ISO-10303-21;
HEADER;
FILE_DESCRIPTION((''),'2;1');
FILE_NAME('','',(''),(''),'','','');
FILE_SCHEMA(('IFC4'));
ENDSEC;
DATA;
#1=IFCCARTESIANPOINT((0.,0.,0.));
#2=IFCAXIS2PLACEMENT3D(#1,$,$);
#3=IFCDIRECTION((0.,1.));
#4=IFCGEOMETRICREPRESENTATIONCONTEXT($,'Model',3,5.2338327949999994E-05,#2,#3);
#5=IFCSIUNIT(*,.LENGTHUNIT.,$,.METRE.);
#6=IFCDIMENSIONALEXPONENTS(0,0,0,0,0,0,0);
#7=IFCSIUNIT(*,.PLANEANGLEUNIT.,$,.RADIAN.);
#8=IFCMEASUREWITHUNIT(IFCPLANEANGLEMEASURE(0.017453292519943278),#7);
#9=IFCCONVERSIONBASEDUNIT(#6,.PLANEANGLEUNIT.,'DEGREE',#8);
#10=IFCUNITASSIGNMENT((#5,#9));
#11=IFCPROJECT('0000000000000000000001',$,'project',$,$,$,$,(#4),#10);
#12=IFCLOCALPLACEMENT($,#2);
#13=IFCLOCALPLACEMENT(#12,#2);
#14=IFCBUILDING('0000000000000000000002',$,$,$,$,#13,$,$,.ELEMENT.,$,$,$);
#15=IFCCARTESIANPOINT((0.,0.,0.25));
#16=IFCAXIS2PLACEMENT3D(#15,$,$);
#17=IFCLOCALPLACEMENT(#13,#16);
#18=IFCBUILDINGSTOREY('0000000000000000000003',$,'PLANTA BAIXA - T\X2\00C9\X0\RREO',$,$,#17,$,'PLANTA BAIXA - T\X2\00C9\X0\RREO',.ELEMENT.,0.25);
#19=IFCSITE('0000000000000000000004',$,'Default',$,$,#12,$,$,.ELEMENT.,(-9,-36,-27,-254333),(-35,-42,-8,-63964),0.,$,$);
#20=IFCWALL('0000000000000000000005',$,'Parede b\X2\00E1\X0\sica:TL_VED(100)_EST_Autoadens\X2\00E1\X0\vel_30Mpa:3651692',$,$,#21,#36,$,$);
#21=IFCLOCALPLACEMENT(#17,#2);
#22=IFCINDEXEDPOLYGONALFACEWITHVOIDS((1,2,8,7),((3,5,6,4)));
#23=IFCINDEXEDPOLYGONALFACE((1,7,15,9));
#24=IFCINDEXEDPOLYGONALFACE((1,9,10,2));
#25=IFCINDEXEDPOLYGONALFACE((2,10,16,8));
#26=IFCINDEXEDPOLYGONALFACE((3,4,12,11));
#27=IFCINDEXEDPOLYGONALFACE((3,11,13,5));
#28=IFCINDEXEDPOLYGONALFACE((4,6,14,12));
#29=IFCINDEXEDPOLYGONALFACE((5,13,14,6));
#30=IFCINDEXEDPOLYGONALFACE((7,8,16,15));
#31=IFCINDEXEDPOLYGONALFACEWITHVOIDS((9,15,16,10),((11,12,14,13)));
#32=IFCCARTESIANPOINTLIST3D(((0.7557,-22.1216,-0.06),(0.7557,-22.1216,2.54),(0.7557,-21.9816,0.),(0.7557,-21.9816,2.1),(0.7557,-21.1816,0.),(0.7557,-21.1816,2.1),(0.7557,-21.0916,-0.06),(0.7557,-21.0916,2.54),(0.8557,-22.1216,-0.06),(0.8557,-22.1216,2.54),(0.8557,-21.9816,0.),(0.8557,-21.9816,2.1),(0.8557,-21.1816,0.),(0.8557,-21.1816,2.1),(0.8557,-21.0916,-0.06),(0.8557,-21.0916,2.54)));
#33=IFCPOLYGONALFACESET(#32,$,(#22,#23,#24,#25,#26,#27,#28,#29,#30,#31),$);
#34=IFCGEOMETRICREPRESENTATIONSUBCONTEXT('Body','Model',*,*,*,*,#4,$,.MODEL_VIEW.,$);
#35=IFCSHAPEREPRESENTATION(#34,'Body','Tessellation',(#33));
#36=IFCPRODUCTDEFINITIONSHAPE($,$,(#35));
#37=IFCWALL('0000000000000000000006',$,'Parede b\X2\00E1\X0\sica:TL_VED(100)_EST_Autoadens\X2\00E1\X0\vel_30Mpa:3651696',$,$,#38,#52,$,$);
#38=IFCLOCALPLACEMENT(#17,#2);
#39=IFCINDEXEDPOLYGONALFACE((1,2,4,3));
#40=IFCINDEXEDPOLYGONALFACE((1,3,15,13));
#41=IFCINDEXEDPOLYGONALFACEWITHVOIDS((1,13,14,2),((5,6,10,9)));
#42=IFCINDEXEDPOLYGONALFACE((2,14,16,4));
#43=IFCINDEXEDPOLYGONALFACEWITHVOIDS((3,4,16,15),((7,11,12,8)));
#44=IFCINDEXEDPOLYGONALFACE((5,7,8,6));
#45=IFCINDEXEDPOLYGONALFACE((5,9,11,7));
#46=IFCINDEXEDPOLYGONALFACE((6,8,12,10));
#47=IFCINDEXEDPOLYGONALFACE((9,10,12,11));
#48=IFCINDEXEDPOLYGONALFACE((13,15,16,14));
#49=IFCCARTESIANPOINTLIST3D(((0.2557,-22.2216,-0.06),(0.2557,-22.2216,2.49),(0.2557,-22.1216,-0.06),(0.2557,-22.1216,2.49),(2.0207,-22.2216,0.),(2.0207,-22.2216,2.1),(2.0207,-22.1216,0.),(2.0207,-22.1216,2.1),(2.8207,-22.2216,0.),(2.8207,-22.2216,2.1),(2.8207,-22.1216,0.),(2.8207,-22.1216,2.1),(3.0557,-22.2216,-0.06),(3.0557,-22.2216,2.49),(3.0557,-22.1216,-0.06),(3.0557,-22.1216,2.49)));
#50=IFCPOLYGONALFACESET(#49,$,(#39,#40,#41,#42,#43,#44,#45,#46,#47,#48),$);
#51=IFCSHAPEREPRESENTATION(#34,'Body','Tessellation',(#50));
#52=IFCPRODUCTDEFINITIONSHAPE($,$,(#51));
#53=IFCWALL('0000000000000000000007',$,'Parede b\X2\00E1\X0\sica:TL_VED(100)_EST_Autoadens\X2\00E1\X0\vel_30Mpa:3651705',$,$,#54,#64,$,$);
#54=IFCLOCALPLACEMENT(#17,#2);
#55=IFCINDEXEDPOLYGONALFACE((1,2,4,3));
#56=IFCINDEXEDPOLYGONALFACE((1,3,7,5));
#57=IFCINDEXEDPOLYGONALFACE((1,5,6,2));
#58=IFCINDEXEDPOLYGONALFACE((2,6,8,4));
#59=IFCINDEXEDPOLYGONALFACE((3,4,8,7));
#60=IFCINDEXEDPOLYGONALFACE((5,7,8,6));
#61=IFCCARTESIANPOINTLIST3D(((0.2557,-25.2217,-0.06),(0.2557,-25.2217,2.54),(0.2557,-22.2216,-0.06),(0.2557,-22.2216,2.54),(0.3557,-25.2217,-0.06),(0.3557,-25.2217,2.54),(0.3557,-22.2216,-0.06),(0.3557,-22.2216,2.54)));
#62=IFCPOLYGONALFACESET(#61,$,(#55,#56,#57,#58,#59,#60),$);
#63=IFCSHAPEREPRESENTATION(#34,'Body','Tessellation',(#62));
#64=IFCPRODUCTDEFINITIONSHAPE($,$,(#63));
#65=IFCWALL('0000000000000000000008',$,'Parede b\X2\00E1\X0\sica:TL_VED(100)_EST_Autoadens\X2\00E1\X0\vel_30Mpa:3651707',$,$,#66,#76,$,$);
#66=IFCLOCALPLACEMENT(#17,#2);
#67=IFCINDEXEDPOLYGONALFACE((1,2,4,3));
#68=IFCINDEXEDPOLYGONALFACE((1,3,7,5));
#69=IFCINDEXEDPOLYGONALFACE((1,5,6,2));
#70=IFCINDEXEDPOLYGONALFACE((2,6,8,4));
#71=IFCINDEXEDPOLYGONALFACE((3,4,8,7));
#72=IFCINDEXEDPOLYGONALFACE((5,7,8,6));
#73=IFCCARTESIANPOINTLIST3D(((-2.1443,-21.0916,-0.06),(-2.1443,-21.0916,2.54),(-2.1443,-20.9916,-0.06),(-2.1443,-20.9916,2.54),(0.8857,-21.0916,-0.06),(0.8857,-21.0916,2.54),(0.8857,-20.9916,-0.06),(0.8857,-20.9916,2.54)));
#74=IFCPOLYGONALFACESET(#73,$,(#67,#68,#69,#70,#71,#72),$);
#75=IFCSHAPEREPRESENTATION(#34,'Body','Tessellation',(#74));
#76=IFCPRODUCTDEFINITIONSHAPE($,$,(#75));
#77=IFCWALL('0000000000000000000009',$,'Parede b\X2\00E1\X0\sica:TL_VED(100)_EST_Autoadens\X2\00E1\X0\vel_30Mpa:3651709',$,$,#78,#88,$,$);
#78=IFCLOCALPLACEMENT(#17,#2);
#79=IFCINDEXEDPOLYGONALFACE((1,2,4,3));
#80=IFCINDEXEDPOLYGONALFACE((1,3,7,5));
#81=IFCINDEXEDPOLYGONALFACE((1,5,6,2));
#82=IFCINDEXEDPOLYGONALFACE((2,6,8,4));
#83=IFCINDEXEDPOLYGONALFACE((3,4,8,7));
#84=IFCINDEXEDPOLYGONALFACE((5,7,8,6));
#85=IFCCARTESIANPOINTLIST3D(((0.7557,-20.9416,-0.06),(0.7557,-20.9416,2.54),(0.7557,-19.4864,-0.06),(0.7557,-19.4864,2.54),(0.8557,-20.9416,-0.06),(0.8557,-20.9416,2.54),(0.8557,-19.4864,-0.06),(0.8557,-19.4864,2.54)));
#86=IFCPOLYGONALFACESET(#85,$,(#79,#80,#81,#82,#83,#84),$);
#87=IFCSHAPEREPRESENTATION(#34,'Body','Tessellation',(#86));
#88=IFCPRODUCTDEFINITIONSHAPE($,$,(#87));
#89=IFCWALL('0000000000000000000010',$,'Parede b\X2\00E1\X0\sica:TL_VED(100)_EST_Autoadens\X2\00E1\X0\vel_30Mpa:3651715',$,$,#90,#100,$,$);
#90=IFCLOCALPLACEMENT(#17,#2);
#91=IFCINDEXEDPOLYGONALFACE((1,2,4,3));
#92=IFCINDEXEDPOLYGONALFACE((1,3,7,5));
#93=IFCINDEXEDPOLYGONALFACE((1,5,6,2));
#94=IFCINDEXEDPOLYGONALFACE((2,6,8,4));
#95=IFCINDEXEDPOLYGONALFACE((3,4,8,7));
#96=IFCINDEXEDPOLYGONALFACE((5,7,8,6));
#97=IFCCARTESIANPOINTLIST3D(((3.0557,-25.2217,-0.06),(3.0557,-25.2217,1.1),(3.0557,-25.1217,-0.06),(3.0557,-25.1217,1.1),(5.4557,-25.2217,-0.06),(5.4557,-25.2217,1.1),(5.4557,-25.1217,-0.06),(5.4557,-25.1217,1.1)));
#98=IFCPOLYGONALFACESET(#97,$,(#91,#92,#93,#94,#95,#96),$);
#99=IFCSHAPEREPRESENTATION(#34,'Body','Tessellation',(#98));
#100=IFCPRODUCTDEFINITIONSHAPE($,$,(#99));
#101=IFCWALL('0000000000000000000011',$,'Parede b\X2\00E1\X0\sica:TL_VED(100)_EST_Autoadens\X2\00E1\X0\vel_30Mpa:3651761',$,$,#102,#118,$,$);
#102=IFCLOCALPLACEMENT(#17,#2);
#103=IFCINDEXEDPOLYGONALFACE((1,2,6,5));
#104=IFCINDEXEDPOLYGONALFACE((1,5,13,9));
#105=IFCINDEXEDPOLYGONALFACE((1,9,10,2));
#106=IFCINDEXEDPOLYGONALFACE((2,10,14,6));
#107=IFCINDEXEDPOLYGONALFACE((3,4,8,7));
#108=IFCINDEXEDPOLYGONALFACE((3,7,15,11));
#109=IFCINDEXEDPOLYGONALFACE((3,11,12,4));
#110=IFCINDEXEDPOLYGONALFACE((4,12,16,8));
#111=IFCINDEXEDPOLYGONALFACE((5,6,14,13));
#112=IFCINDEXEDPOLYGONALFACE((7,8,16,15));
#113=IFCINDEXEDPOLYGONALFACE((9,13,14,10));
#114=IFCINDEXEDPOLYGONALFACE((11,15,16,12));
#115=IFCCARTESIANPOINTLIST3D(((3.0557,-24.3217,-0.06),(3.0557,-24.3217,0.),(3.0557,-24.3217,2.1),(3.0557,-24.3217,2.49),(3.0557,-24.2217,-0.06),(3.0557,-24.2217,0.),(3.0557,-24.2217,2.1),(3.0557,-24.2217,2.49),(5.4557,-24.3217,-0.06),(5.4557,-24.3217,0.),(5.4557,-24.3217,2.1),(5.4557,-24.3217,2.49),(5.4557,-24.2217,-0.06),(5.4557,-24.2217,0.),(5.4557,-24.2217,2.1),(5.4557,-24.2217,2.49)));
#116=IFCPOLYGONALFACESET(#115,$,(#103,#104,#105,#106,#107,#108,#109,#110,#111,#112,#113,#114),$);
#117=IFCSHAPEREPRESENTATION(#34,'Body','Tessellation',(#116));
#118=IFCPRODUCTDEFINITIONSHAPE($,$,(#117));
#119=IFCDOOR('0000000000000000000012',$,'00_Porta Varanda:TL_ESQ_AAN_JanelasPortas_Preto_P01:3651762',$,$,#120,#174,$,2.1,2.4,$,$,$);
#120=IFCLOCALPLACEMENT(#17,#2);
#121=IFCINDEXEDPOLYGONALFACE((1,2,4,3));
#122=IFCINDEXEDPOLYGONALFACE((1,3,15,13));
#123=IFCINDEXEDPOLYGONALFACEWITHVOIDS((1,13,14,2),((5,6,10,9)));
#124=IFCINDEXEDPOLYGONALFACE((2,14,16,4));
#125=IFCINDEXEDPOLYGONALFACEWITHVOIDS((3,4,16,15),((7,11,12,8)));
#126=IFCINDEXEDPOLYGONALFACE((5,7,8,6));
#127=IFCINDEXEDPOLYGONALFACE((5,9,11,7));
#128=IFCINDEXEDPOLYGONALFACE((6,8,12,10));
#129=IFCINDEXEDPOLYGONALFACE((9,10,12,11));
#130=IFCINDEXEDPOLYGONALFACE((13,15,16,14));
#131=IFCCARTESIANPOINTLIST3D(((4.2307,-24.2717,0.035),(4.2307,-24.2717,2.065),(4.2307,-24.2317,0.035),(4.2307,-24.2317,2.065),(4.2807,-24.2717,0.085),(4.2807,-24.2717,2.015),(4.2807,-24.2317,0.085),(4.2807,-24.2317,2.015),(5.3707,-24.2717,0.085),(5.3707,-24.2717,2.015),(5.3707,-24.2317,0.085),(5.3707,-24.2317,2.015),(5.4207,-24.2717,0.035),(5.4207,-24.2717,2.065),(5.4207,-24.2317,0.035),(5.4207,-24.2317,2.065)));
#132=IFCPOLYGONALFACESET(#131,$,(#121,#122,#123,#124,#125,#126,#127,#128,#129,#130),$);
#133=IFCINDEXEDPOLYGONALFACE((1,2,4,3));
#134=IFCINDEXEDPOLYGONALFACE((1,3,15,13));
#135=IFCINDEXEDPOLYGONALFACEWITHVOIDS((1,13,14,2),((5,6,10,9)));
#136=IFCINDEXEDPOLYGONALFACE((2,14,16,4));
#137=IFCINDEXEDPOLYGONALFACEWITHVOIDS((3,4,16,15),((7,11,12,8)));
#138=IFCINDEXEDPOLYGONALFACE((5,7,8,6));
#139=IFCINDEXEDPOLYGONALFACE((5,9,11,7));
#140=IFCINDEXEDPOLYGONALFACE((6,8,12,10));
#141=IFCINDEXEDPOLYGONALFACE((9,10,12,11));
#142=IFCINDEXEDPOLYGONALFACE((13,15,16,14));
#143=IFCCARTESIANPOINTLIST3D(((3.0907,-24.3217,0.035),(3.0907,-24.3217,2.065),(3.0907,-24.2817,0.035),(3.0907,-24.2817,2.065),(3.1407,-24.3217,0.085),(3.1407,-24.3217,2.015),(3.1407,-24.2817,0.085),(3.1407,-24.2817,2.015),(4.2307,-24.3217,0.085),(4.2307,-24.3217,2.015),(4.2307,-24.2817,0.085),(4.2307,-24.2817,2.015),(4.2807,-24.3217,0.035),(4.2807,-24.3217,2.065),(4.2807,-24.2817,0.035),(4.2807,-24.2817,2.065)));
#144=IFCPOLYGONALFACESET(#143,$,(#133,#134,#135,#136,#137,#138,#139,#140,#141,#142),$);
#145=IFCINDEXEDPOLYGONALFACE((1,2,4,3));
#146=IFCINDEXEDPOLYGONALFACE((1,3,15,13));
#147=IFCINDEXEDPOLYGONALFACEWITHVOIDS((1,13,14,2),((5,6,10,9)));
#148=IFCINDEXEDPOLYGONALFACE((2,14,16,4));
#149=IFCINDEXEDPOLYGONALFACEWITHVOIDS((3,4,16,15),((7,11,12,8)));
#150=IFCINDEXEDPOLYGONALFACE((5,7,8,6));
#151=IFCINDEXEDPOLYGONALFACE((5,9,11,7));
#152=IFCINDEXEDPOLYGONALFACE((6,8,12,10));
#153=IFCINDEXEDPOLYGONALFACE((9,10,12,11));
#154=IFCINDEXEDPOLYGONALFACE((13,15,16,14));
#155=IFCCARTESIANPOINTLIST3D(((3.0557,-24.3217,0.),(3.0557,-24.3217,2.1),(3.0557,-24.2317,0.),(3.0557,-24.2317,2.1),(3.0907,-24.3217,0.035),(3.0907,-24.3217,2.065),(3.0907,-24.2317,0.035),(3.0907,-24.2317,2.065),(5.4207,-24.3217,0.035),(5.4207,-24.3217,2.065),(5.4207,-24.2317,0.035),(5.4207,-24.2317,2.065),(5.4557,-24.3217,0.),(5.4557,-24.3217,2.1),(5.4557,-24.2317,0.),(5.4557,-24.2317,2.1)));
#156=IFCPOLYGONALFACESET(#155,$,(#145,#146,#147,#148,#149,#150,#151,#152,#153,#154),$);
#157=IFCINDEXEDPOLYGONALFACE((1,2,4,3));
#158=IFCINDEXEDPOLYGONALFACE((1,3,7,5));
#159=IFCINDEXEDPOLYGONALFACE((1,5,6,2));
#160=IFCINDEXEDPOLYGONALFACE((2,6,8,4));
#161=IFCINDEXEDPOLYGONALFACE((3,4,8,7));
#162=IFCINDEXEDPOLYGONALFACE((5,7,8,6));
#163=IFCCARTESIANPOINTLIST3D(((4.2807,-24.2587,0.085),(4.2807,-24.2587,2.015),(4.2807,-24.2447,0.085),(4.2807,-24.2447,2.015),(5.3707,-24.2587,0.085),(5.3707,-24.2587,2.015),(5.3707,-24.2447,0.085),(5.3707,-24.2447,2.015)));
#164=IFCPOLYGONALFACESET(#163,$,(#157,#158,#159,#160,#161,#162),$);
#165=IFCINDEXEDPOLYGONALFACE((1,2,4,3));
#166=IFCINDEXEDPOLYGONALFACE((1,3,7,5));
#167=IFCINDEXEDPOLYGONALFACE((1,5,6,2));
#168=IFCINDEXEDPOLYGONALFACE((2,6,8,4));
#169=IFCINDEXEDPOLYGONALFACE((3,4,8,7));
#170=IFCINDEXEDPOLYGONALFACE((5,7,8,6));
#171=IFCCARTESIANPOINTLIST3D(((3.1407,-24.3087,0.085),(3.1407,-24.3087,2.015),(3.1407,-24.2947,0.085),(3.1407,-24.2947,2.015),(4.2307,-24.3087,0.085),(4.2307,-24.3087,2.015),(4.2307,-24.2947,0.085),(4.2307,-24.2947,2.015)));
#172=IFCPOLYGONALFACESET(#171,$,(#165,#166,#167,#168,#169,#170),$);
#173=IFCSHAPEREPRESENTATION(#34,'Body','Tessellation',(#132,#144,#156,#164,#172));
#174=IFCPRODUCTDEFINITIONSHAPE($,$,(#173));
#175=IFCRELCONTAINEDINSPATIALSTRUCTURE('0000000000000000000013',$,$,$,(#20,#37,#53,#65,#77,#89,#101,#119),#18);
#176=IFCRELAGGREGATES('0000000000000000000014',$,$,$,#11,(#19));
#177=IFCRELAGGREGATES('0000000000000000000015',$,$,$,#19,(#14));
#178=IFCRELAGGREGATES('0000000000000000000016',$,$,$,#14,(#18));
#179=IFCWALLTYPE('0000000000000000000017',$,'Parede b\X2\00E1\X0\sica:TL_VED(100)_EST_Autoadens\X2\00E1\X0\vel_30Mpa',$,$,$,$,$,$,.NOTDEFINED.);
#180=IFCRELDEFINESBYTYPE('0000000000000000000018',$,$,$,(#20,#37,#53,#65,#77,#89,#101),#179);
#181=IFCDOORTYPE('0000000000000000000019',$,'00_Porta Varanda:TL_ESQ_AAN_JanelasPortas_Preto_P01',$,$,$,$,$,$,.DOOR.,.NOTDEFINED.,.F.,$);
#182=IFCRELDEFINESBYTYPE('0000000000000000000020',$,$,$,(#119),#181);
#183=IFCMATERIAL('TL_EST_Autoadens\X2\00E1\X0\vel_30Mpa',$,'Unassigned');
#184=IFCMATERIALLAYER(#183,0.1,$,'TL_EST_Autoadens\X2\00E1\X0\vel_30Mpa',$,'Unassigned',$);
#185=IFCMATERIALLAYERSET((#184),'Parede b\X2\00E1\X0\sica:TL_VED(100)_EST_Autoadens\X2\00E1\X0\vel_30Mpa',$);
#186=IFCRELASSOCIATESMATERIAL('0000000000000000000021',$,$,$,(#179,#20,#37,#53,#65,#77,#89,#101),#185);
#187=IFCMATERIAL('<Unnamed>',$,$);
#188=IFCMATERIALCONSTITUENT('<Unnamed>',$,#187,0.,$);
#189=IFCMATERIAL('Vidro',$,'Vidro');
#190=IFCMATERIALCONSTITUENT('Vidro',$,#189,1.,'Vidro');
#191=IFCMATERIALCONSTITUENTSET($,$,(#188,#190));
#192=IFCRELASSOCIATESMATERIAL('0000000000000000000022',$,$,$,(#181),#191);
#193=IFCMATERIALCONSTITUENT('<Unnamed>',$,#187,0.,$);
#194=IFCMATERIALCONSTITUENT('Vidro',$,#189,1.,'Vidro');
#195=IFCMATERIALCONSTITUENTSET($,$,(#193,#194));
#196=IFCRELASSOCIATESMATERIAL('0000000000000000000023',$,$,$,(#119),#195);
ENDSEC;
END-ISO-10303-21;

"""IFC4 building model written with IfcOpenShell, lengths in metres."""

from ifc_helpers import new_model, entity, si_unit, converted_unit, direction, frame, frame_2d, origin, place, context, subcontext, project, spatial, polyline, rectangle, outline, extrude, source, transform, mapped, material, layer, layer_set, layer_usage, constituent, constituent_set, type_object, type_shapes, element, fill, save


model = new_model("IFC4")

# Units and contexts
model_context = context("Model", 3, precision=5.2338327949999994e-05, world=origin(), true_north=direction((0.0, 1.0)))
body_context = subcontext(model_context, "Body", "Model", "MODEL_VIEW")
ifc_project = project(units=[si_unit("LENGTHUNIT", "METRE"), converted_unit("PLANEANGLEUNIT", "DEGREE", entity("IfcPlaneAngleMeasure", 0.017453292519943278), si_unit("PLANEANGLEUNIT", "RADIAN"), dimensions=[0, 0, 0, 0, 0, 0, 0])], contexts=[model_context])

# Site, building, storey
site_placement = place(None, frame((0.0, 0.0, 0.0)))
site = spatial("IfcSite", under=ifc_project, at=site_placement, Name="Default", CompositionType="ELEMENT", RefLatitude=(-9, -36, -27, -254333), RefLongitude=(-35, -42, -8, -63964), RefElevation=0.0)
building_placement = place(site_placement, origin())
building = spatial("IfcBuilding", under=site, at=building_placement, CompositionType="ELEMENT")
storey_placement = place(building_placement, frame((0.0, 0.0, 0.25)))
storey = spatial("IfcBuildingStorey", under=building, at=storey_placement, Name="PLANTA BAIXA - TÉRREO", LongName="PLANTA BAIXA - TÉRREO", CompositionType="ELEMENT", Elevation=0.25)

# Walls, openings
ifc_material_1 = material(Name="TL_EST_Autoadensável_30Mpa", Category="Unassigned")
ifc_layer_1 = layer(ifc_material_1, 0.1, Name="TL_EST_Autoadensável_30Mpa", Category="Unassigned")
ifc_layer_set_1 = layer_set([ifc_layer_1], Name="Parede básica:TL_VED(100)_EST_Autoadensável_30Mpa")
ifc_layer_usage_1 = layer_usage(ifc_layer_set_1, "AXIS2", "NEGATIVE", 0.05)
wall_type_1 = type_object("IfcWallType", Name="Parede básica:TL_VED(100)_EST_Autoadensável_30Mpa", PredefinedType="NOTDEFINED", material=ifc_layer_set_1)
wall_1_placement = place(storey_placement, frame((0.8057, -22.1216, -0.06), z_axis=(0.0, 0.0, 1.0), x_axis=(0.0, 1.0, 0.0)))
wall_1 = element("IfcWall", 1, at=wall_1_placement, inside=storey, type_object=wall_type_1, material=ifc_layer_usage_1, Name="Parede básica:TL_VED(100)_EST_Autoadensável_30Mpa:3651692", context=body_context, shape_type="SweptSolid", body=[
    extrude(rectangle(XDim=1.03, YDim=0.1, at=frame_2d((0.515, 0.0), x_axis=(-1.0, 0.0))), origin(), (0.0, 0.0, 1.0), 2.6),
])
opening_1_placement = place(wall_1_placement, frame((0.14, -0.05, 0.06)))
element("IfcOpeningElement", 2, at=opening_1_placement, cuts=wall_1, PredefinedType="OPENING", context=body_context, shape_type="SweptSolid", body=[
    extrude(rectangle(XDim=2.1, YDim=0.8, at=frame_2d((1.05, 0.4), x_axis=(1.0, 0.0))), frame((0.0, 0.0, 0.0), z_axis=(0.0, 1.0, 0.0), x_axis=(0.0, 0.0, 1.0)), (0.0, 0.0, 1.0), 0.1),
])
ifc_layer_usage_2 = layer_usage(ifc_layer_set_1, "AXIS2", "NEGATIVE", 0.05)
wall_2_placement = place(storey_placement, frame((3.0557, -22.1716, -0.06), z_axis=(0.0, 0.0, 1.0), x_axis=(-1.0, 0.0, 0.0)))
wall_2 = element("IfcWall", 3, at=wall_2_placement, inside=storey, type_object=wall_type_1, material=ifc_layer_usage_2, Name="Parede básica:TL_VED(100)_EST_Autoadensável_30Mpa:3651696", context=body_context, shape_type="SweptSolid", body=[
    extrude(rectangle(XDim=2.8, YDim=0.1, at=frame_2d((1.4, 0.0), x_axis=(-1.0, 0.0))), origin(), (0.0, 0.0, 1.0), 2.55),
])
opening_2_placement = place(wall_2_placement, frame((0.235, -0.05, 0.06)))
element("IfcOpeningElement", 4, at=opening_2_placement, cuts=wall_2, PredefinedType="OPENING", context=body_context, shape_type="SweptSolid", body=[
    extrude(rectangle(XDim=2.1, YDim=0.8, at=frame_2d((1.05, 0.4), x_axis=(1.0, 0.0))), frame((0.0, 0.0, 0.0), z_axis=(0.0, 1.0, 0.0), x_axis=(0.0, 0.0, 1.0)), (0.0, 0.0, 1.0), 0.1),
])

# Walls
ifc_layer_usage_3 = layer_usage(ifc_layer_set_1, "AXIS2", "POSITIVE", -0.05)
wall_3_placement = place(storey_placement, frame((0.3057, -25.2217, -0.06), z_axis=(0.0, 0.0, 1.0), x_axis=(0.0, 1.0, 0.0)))
element("IfcWall", 5, at=wall_3_placement, inside=storey, type_object=wall_type_1, material=ifc_layer_usage_3, Name="Parede básica:TL_VED(100)_EST_Autoadensável_30Mpa:3651705", context=body_context, shape_type="SweptSolid", body=[
    extrude(rectangle(XDim=3.0001, YDim=0.1, at=frame_2d((1.5001, 0.0), x_axis=(-1.0, 0.0))), origin(), (0.0, 0.0, 1.0), 2.6),
])
ifc_layer_usage_4 = layer_usage(ifc_layer_set_1, "AXIS2", "POSITIVE", -0.05)
wall_4_placement = place(storey_placement, frame((0.8857, -21.0416, -0.06), z_axis=(0.0, 0.0, 1.0), x_axis=(-1.0, 0.0, 0.0)))
element("IfcWall", 6, at=wall_4_placement, inside=storey, type_object=wall_type_1, material=ifc_layer_usage_4, Name="Parede básica:TL_VED(100)_EST_Autoadensável_30Mpa:3651707", context=body_context, shape_type="SweptSolid", body=[
    extrude(rectangle(XDim=3.03, YDim=0.1, at=frame_2d((1.515, 0.0), x_axis=(-1.0, 0.0))), origin(), (0.0, 0.0, 1.0), 2.6),
])
ifc_layer_usage_5 = layer_usage(ifc_layer_set_1, "AXIS2", "NEGATIVE", 0.05)
wall_5_placement = place(storey_placement, frame((0.8057, -19.4864, -0.06), z_axis=(0.0, 0.0, 1.0), x_axis=(0.0, -1.0, 0.0)))
element("IfcWall", 7, at=wall_5_placement, inside=storey, type_object=wall_type_1, material=ifc_layer_usage_5, Name="Parede básica:TL_VED(100)_EST_Autoadensável_30Mpa:3651709", context=body_context, shape_type="SweptSolid", body=[
    extrude(rectangle(XDim=1.4552, YDim=0.1, at=frame_2d((0.7276, 0.0), x_axis=(-1.0, 0.0))), origin(), (0.0, 0.0, 1.0), 2.6),
])

# Wall
ifc_layer_usage_6 = layer_usage(ifc_layer_set_1, "AXIS2", "POSITIVE", -0.05)
wall_6_placement = place(storey_placement, frame((3.0557, -25.1717, -0.06)))
element("IfcWall", 8, at=wall_6_placement, inside=storey, type_object=wall_type_1, material=ifc_layer_usage_6, Name="Parede básica:TL_VED(100)_EST_Autoadensável_30Mpa:3651715", context=body_context, shape_type="SweptSolid", body=[
    extrude(rectangle(XDim=2.4, YDim=0.1, at=frame_2d((1.2, 0.0), x_axis=(-1.0, 0.0))), origin(), (0.0, 0.0, 1.0), 1.16),
])

# Wall, opening, door
ifc_layer_usage_7 = layer_usage(ifc_layer_set_1, "AXIS2", "POSITIVE", -0.05)
wall_7_placement = place(storey_placement, frame((3.0557, -24.2717, -0.06)))
wall_7 = element("IfcWall", 9, at=wall_7_placement, inside=storey, type_object=wall_type_1, material=ifc_layer_usage_7, Name="Parede básica:TL_VED(100)_EST_Autoadensável_30Mpa:3651761", context=body_context, shape_type="SweptSolid", body=[
    extrude(rectangle(XDim=2.4, YDim=0.1, at=frame_2d((1.2, 0.0), x_axis=(-1.0, 0.0))), origin(), (0.0, 0.0, 1.0), 2.55),
])
opening_3_placement = place(wall_7_placement, frame((0.0, -0.05, 0.06)))
opening_3 = element("IfcOpeningElement", 10, at=opening_3_placement, cuts=wall_7, PredefinedType="OPENING", context=body_context, shape_type="SweptSolid", body=[
    extrude(rectangle(XDim=2.1, YDim=2.4, at=frame_2d((1.05, 1.2), x_axis=(1.0, 0.0))), frame((0.0, 0.0, 0.0), z_axis=(0.0, 1.0, 0.0), x_axis=(0.0, 0.0, 1.0)), (0.0, 0.0, 1.0), 0.1),
])
ifc_material_2 = material(Name="<Unnamed>")
ifc_constituent_1 = constituent(ifc_material_2, Name="<Unnamed>", fraction=0.0)
ifc_material_3 = material(Name="Vidro", Category="Vidro")
ifc_constituent_2 = constituent(ifc_material_3, Name="Vidro", Category="Vidro", fraction=1.0)
ifc_constituent_set_1 = constituent_set(constituents=[ifc_constituent_1, ifc_constituent_2])
ifc_constituent_3 = constituent(ifc_material_2, Name="<Unnamed>", fraction=0.0)
ifc_constituent_4 = constituent(ifc_material_3, Name="Vidro", Category="Vidro", fraction=1.0)
ifc_constituent_set_2 = constituent_set(constituents=[ifc_constituent_3, ifc_constituent_4])
door_type = type_object("IfcDoorType", Name="00_Porta Varanda:TL_ESQ_AAN_JanelasPortas_Preto_P01", OperationType="NOTDEFINED", ParameterTakesPrecedence=False, PredefinedType="DOOR", material=ifc_constituent_set_2)
shared_shape_1 = source(origin(), body_context, "Body", "SweptSolid", [
    extrude(outline(polyline([(-1.015, -0.595), (1.015, -0.595), (1.015, 0.595), (-1.015, 0.595), (-1.015, -0.595)]), holes=[polyline([(0.965, -0.545), (-0.965, -0.545), (-0.965, 0.545), (0.965, 0.545), (0.965, -0.545)])]), frame((1.77, 0.05, 1.05), z_axis=(0.0, 1.0, 0.0), x_axis=(0.0, 0.0, 1.0)), (0.0, 0.0, 1.0), 0.04),
    extrude(outline(polyline([(-1.015, -0.595), (1.015, -0.595), (1.015, 0.595), (-1.015, 0.595), (-1.015, -0.595)]), holes=[polyline([(0.965, -0.545), (-0.965, -0.545), (-0.965, 0.545), (0.965, 0.545), (0.965, -0.545)])]), frame((0.63, 0.0, 1.05), z_axis=(0.0, 1.0, 0.0), x_axis=(0.0, 0.0, -1.0)), (0.0, 0.0, 1.0), 0.04),
    extrude(outline(polyline([(-1.05, -1.2), (1.05, -1.2), (1.05, 1.2), (-1.05, 1.2), (-1.05, -1.2)]), holes=[polyline([(1.015, -1.165), (-1.015, -1.165), (-1.015, 1.165), (1.015, 1.165), (1.015, -1.165)])]), frame((1.2, 0.0, 1.05), z_axis=(0.0, 1.0, 0.0), x_axis=(0.0, 0.0, -1.0)), (0.0, 0.0, 1.0), 0.09),
    extrude(rectangle(XDim=0.014, YDim=1.09, at=frame_2d((0.0, 0.0), x_axis=(1.0, 0.0))), frame((1.77, 0.07, 0.085), z_axis=(0.0, 0.0, 1.0), x_axis=(0.0, -1.0, 0.0)), (0.0, 0.0, 1.0), 1.93),
    extrude(rectangle(XDim=0.014, YDim=1.09, at=frame_2d((0.0, 0.0), x_axis=(1.0, 0.0))), frame((0.63, 0.02, 0.085), z_axis=(0.0, 0.0, 1.0), x_axis=(0.0, -1.0, 0.0)), (0.0, 0.0, 1.0), 1.93),
])
type_shapes(door_type, [shared_shape_1])
door_placement = place(opening_3_placement, origin())
door = element("IfcDoor", 11, at=door_placement, inside=storey, type_object=door_type, material=ifc_constituent_set_1, Name="00_Porta Varanda:TL_ESQ_AAN_JanelasPortas_Preto_P01:3651762", OverallHeight=2.1, OverallWidth=2.4, context=body_context, shape_type="MappedRepresentation", body=[
    mapped(shared_shape_1, transform((0.0, 0.0, 0.0), scale=1.0)),
])
fill(opening_3, door)

save(model, "model.ifc")
